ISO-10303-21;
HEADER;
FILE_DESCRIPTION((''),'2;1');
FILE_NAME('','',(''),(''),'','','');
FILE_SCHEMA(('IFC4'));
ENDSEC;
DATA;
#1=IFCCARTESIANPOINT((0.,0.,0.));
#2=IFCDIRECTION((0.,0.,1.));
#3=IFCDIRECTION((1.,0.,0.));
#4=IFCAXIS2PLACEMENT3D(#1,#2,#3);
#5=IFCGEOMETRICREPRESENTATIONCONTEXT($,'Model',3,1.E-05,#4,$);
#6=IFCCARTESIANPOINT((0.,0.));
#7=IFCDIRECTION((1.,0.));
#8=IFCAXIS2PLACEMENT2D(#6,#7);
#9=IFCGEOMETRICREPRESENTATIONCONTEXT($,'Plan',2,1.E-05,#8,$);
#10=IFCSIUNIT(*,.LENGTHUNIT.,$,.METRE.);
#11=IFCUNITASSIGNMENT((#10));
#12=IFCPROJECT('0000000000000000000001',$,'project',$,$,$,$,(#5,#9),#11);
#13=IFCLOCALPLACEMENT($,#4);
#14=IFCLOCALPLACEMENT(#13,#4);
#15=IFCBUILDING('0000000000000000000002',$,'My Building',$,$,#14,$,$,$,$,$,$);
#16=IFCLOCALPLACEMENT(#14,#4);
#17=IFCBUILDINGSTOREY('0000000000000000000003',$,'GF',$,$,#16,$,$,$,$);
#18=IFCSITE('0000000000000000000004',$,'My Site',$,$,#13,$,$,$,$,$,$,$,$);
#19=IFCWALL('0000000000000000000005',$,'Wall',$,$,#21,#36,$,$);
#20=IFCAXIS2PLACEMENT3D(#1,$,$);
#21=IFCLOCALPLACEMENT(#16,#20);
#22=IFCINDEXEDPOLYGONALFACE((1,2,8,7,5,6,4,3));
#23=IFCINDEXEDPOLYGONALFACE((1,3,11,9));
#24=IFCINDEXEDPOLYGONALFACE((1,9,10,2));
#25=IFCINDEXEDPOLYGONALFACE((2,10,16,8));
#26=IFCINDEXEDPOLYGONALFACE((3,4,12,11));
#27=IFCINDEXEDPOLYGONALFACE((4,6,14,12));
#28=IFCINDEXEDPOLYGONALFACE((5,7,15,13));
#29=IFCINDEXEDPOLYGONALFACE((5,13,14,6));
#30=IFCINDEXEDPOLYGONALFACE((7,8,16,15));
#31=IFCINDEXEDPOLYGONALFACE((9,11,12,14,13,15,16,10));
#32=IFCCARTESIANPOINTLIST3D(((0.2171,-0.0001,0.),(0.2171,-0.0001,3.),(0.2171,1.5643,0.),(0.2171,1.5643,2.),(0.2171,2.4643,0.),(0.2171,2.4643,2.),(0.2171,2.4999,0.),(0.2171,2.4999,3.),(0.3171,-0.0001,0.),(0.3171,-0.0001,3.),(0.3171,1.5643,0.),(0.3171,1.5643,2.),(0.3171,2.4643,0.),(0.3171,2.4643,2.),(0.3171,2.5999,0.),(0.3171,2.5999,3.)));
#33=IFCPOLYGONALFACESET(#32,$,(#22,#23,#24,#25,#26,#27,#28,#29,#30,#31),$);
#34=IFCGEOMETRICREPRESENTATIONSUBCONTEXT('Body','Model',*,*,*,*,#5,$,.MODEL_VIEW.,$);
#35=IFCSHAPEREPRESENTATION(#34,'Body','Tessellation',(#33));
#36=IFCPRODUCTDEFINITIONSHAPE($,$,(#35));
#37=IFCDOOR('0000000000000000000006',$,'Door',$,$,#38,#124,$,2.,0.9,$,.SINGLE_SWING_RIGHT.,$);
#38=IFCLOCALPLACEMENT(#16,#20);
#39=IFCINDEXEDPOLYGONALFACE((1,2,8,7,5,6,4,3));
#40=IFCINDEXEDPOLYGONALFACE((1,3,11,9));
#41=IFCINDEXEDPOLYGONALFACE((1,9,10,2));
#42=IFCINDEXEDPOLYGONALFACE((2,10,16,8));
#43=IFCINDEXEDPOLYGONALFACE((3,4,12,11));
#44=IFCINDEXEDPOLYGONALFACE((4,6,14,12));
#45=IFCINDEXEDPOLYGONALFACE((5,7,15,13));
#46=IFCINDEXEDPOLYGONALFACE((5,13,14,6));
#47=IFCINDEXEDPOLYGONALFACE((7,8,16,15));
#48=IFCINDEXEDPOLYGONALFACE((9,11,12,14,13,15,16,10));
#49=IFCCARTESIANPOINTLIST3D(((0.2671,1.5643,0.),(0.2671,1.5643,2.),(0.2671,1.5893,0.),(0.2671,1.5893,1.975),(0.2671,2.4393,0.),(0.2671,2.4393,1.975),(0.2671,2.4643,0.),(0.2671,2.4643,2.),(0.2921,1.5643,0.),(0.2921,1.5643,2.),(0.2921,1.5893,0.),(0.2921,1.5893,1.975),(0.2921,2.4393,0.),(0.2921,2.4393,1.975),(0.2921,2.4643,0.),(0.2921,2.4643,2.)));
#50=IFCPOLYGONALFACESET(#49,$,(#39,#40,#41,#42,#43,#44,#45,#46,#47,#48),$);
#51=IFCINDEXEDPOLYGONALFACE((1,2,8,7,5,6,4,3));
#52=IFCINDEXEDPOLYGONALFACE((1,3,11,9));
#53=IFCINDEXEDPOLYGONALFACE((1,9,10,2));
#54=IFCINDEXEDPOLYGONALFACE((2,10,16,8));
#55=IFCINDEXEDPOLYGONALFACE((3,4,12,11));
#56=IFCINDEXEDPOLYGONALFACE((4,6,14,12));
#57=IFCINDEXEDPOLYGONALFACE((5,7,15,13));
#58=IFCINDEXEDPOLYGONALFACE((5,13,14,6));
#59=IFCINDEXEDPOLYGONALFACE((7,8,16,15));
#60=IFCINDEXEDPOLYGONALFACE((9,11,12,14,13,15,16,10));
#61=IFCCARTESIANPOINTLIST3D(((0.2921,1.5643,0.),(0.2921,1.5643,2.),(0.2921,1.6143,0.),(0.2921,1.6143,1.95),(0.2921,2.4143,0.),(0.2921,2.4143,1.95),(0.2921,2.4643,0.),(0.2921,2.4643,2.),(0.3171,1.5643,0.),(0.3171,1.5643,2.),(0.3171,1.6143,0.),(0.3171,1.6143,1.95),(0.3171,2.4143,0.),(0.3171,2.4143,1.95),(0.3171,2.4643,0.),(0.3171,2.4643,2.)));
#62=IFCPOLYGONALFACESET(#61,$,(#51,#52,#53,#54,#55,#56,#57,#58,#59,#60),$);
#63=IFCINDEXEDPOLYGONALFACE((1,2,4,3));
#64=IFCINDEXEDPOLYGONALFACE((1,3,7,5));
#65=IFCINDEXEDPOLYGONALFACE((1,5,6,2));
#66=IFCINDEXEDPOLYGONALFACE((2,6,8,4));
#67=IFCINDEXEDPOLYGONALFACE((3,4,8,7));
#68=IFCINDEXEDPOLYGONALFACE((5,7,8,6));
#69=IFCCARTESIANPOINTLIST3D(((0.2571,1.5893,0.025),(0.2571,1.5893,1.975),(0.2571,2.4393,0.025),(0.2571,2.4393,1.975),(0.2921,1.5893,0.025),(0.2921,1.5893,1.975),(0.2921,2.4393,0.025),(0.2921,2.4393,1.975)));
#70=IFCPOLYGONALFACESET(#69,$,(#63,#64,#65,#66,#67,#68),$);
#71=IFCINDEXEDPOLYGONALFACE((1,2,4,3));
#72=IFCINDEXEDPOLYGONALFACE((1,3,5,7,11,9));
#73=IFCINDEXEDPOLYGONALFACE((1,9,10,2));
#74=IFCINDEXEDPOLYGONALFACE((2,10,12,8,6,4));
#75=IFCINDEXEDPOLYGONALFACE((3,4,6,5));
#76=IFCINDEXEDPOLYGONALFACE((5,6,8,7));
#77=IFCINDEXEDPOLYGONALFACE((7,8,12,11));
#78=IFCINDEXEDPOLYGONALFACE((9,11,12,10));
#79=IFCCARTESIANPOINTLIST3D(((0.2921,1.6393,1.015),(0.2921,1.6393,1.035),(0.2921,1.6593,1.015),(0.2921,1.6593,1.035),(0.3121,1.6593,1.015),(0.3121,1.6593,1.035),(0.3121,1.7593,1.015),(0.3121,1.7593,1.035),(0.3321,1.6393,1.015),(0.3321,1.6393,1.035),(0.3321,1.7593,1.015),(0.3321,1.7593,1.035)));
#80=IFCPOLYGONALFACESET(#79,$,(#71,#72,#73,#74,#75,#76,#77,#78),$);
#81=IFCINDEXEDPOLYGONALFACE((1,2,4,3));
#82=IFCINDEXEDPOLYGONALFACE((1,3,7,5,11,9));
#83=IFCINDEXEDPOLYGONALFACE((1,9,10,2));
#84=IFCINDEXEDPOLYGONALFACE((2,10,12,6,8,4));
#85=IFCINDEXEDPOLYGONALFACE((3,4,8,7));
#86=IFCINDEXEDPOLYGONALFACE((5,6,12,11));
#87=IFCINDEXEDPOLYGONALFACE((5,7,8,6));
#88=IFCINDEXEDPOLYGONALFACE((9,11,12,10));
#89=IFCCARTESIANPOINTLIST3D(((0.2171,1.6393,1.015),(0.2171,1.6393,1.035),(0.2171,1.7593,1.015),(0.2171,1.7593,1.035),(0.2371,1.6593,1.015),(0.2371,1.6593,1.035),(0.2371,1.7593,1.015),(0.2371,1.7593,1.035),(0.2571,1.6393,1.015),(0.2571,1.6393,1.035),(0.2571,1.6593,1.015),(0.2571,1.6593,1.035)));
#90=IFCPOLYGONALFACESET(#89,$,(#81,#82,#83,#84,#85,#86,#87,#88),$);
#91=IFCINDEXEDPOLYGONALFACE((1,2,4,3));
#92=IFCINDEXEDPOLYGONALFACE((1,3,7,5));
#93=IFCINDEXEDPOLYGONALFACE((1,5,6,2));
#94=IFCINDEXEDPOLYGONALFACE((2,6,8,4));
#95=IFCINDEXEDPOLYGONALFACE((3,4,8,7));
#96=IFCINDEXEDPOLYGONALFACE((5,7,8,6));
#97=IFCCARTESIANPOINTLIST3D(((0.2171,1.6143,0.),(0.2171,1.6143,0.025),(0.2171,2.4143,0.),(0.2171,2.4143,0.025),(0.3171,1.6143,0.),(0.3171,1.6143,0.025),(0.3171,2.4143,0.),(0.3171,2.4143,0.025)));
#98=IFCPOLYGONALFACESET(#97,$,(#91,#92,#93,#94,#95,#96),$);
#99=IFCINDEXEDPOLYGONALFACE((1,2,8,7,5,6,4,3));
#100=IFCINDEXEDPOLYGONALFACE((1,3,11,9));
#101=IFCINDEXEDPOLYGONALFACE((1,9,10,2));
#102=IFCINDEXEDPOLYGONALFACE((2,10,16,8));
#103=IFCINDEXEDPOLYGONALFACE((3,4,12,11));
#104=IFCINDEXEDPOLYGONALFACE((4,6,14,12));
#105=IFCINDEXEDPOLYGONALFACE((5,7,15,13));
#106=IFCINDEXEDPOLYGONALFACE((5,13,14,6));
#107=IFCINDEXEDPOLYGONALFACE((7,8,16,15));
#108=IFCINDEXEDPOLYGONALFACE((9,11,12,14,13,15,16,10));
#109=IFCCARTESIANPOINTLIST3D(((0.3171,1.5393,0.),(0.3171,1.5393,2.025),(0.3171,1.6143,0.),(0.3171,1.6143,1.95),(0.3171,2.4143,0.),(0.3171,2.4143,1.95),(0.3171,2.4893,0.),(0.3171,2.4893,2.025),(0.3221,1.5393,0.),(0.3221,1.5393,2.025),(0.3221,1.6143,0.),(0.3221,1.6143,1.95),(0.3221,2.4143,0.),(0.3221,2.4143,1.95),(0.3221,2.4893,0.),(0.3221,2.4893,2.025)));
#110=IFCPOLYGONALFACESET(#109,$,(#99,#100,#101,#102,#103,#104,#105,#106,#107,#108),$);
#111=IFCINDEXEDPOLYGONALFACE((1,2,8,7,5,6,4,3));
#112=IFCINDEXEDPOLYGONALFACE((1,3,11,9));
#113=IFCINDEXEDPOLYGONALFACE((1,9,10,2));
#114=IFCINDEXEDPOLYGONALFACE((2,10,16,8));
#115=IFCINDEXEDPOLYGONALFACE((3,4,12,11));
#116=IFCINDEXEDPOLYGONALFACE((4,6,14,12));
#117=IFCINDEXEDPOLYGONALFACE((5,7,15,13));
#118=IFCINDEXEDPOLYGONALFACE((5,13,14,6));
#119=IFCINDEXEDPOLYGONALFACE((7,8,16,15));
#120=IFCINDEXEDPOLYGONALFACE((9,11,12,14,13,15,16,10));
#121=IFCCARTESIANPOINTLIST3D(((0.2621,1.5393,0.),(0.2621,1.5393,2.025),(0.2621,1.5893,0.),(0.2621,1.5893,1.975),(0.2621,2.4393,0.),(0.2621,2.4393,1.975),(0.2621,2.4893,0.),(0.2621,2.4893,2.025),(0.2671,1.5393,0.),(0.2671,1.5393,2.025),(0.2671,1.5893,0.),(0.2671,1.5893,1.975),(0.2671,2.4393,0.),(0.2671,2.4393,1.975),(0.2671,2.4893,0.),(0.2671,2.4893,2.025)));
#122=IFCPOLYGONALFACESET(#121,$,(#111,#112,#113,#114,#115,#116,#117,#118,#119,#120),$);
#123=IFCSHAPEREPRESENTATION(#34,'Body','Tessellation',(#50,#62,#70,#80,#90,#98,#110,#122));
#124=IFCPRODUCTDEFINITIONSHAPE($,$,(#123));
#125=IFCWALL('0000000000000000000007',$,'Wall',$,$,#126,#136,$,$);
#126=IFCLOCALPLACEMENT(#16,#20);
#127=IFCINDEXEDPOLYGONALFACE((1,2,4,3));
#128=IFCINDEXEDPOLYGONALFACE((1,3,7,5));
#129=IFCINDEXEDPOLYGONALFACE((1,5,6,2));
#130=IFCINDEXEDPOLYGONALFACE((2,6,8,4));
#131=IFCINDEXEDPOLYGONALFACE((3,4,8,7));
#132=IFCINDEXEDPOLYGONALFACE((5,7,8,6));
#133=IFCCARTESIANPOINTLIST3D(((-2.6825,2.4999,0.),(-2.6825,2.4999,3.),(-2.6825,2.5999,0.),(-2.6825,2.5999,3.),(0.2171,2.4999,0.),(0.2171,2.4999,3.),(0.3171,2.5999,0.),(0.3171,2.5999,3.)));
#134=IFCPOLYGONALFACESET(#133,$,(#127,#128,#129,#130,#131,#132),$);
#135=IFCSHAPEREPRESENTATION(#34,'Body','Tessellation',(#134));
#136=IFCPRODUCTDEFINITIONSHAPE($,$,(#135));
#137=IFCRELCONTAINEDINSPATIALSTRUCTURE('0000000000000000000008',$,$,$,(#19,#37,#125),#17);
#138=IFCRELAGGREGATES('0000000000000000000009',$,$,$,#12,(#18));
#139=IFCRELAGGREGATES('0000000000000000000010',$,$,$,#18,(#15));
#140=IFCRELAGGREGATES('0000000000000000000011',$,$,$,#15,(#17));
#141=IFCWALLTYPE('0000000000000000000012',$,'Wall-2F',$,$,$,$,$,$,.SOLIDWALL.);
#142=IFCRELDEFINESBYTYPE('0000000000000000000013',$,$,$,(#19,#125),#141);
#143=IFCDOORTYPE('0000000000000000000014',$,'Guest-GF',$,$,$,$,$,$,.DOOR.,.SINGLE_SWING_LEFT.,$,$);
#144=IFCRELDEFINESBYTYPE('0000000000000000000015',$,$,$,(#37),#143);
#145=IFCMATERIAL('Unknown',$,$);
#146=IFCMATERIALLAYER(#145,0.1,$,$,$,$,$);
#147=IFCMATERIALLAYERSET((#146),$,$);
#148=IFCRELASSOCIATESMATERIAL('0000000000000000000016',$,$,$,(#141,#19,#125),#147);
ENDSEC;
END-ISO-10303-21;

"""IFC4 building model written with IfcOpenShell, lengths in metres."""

from ifc_helpers import new_model, entity, si_unit, frame, origin_with_axes, origin_2d_with_axis, place, context, subcontext, project, spatial, line, indexed_curve, outline, extrude, shape, source, transform, mapped, material, layer, layer_set, layer_usage, type_object, type_shapes, element, fill, save


model = new_model("IFC4")

# Units and contexts
model_context = context("Model", 3, precision=1e-05, world=origin_with_axes())
plan_context = context("Plan", 2, precision=1e-05, world=origin_2d_with_axis())
body_context_1 = subcontext(model_context, "Body", "Model", "MODEL_VIEW")
body_context_2 = subcontext(plan_context, "Body", "Plan", "PLAN_VIEW")
ifc_project = project(units=[si_unit("LENGTHUNIT", "METRE")], contexts=[model_context, plan_context])

# Site, building, storey
site_placement = place(None, origin_with_axes())
site = spatial("IfcSite", under=ifc_project, at=site_placement, Name="My Site")
building_placement = place(site_placement, origin_with_axes())
building = spatial("IfcBuilding", under=site, at=building_placement, Name="My Building")
storey_placement = place(building_placement, origin_with_axes())
storey = spatial("IfcBuildingStorey", under=building, at=storey_placement, Name="GF")

# Shared definitions
ifc_material = material(Name="Unknown")

# Shared definitions
ifc_layer_1 = layer(ifc_material, 0.1)
ifc_layer_set_1 = layer_set([ifc_layer_1])
wall_type = type_object("IfcWallType", Name="Wall-2F", PredefinedType="SOLIDWALL", material=ifc_layer_set_1)

# Wall, opening, door
ifc_layer_usage_1 = layer_usage(ifc_layer_set_1, "AXIS2", "POSITIVE", 0.0)
wall_1_placement = place(storey_placement, frame((0.3171, -0.0001, 0.0), z_axis=(0.0, 0.0, 1.0), x_axis=(0.0, 1.0, 0.0)))
wall_1 = element("IfcWall", 1, at=wall_1_placement, inside=storey, type_object=wall_type, material=ifc_layer_usage_1, Name="Wall", context=body_context_1, shape_type="SweptSolid", body=[
    extrude(outline(indexed_curve([(0.0, 0.0), (0.0, 0.1), (2.5, 0.1), (2.6, 0.0)], segments=[line(1, 2, 3, 4, 1)])), origin_with_axes(), (0.0, 0.0, 1.0), 3.0),
])
shared_shape_1 = source(origin_with_axes(), body_context_1, "Body", "SweptSolid", [
    extrude(outline(indexed_curve([(0.0, 0.0), (0.9, 0.0), (0.9, 2.0), (0.0, 2.0)], segments=[line(1, 2, 3, 4, 1)])), frame((0.0, -0.6, 0.0), z_axis=(0.0, -1.0, 0.0), x_axis=(1.0, 0.0, 0.0)), (0.0, 0.0, -1.0), 1.2),
])
opening_1_placement = place(wall_1_placement, frame((1.5644, 0.0, 0.0), z_axis=(0.0, 0.0, 1.0), x_axis=(1.0, 0.0, 0.0)))
opening_1 = element("IfcOpeningElement", 2, at=opening_1_placement, cuts=wall_1, PredefinedType="OPENING", context=body_context_1, shape_type="MappedRepresentation", body=[
    mapped(shared_shape_1, transform((0.0, 0.0, 0.0), x_axis=(1.0, 0.0, 0.0), y_axis=(0.0, 1.0, 0.0), z_axis=(0.0, 0.0, 1.0), scale=1.0)),
])
door_type_1 = type_object("IfcDoorType", Name="Guest-GF", OperationType="SINGLE_SWING_LEFT", PredefinedType="DOOR")
shared_shape_2 = source(origin_with_axes(), body_context_1, "Body", "SweptSolid", [
    extrude(outline(indexed_curve([(0.0, 0.0), (0.0, 2.0), (0.9, 2.0), (0.9, 0.0), (0.875, 0.0), (0.875, 1.975), (0.025, 1.975), (0.025, 0.0)], segments=[line(1, 2, 3, 4, 5, 6, 7, 8, 1)])), frame((0.0, 0.025, 0.0), z_axis=(0.0, -1.0, 0.0), x_axis=(1.0, 0.0, 0.0)), (0.0, 0.0, -1.0), 0.025),
    extrude(outline(indexed_curve([(0.0, 0.0), (0.0, 2.0), (0.9, 2.0), (0.9, 0.0), (0.85, 0.0), (0.85, 1.95), (0.05, 1.95), (0.05, 0.0)], segments=[line(1, 2, 3, 4, 5, 6, 7, 8, 1)])), frame((0.0, 0.0, 0.0), z_axis=(0.0, -1.0, 0.0), x_axis=(1.0, 0.0, 0.0)), (0.0, 0.0, -1.0), 0.025),
    extrude(outline(indexed_curve([(0.0, 0.0), (0.85, 0.0), (0.85, 0.035), (0.0, 0.035)], segments=[line(1, 2, 3, 4, 1)])), frame((0.025, 0.025, 0.025), z_axis=(0.0, 0.0, 1.0), x_axis=(1.0, 0.0, 0.0)), (0.0, 0.0, 1.0), 1.95),
    extrude(outline(indexed_curve([(0.0, 0.0), (0.0, -0.04), (0.12, -0.04), (0.12, -0.02), (0.02, -0.02), (0.02, 0.0)], segments=[line(1, 2, 3, 4, 5, 6, 1)])), frame((0.075, 0.025, 1.015), z_axis=(0.0, 0.0, 1.0), x_axis=(1.0, 0.0, 0.0)), (0.0, 0.0, 1.0), 0.02),
    extrude(outline(indexed_curve([(0.0, 0.0), (0.0, 0.04), (0.12, 0.04), (0.12, 0.02), (0.02, 0.02), (0.02, 0.0)], segments=[line(1, 2, 3, 4, 5, 6, 1)])), frame((0.075, 0.06, 1.015), z_axis=(0.0, 0.0, 1.0), x_axis=(1.0, 0.0, 0.0)), (0.0, 0.0, 1.0), 0.02),
    extrude(outline(indexed_curve([(0.0, 0.0), (0.8, 0.0), (0.8, 0.1), (0.0, 0.1)], segments=[line(1, 2, 3, 4, 1)])), frame((0.05, 0.0, 0.0), z_axis=(0.0, 0.0, 1.0), x_axis=(1.0, 0.0, 0.0)), (0.0, 0.0, 1.0), 0.025),
    extrude(outline(indexed_curve([(0.0, 0.0), (0.0, 2.025), (0.95, 2.025), (0.95, 0.0), (0.875, 0.0), (0.875, 1.95), (0.075, 1.95), (0.075, 0.0)], segments=[line(1, 2, 3, 4, 5, 6, 7, 8, 1)])), frame((-0.025, -0.005, 0.0), z_axis=(0.0, -1.0, 0.0), x_axis=(1.0, 0.0, 0.0)), (0.0, 0.0, -1.0), 0.005),
    extrude(outline(indexed_curve([(0.0, 0.0), (0.0, 2.025), (0.95, 2.025), (0.95, 0.0), (0.9, 0.0), (0.9, 1.975), (0.05, 1.975), (0.05, 0.0)], segments=[line(1, 2, 3, 4, 5, 6, 7, 8, 1)])), frame((-0.025, 0.05, 0.0), z_axis=(0.0, -1.0, 0.0), x_axis=(1.0, 0.0, 0.0)), (0.0, 0.0, -1.0), 0.005),
])
shared_shape_3 = source(origin_with_axes(), body_context_2, "Body", "Curve2D", [
    entity("IfcIndexedPolyCurve", entity("IfcCartesianPointList2D", [[0.0, 0.0], [0.0, 0.05], [0.025, 0.05], [0.025, 0.025], [0.05, 0.025], [0.05, 0.0]]), [entity("IfcLineIndex", [1, 2, 3, 4, 5, 6, 1])]),
    entity("IfcIndexedPolyCurve", entity("IfcCartesianPointList2D", [[0.9, 0.0], [0.9, 0.05], [0.875, 0.05], [0.875, 0.025], [0.85, 0.025], [0.85, 0.0]]), [entity("IfcLineIndex", [1, 2, 3, 4, 5, 6, 1])]),
    entity("IfcTrimmedCurve", entity("IfcEllipse", entity("IfcAxis2Placement2D", entity("IfcCartesianPoint", [0.84, 0.05]), entity("IfcDirection", [1.0, 0.0])), 0.815, 0.85), [entity("IfcCartesianPoint", [0.84, 0.9])], [entity("IfcCartesianPoint", [0.025, 0.05])], True, "CARTESIAN"),
    entity("IfcIndexedPolyCurve", entity("IfcCartesianPointList2D", [[0.875, 0.05], [0.84, 0.05], [0.84, 0.9], [0.875, 0.9]]), [entity("IfcLineIndex", [1, 2, 3, 4, 1])]),
])
type_shapes(door_type_1, [shared_shape_2, shared_shape_3])
door_1_placement = place(opening_1_placement, frame((0.0, 0.0, 0.0), z_axis=(0.0, 0.0, 1.0), x_axis=(1.0, 0.0, 0.0)))
door_1 = element("IfcDoor", 3, at=door_1_placement, inside=storey, type_object=door_type_1, Name="Door", OperationType="SINGLE_SWING_RIGHT", OverallHeight=2.0, OverallWidth=0.9, shapes=[
    shape(body_context_1, "Body", "MappedRepresentation", [mapped(shared_shape_2, transform((0.0, 0.0, 0.0), x_axis=(1.0, 0.0, 0.0), y_axis=(0.0, 1.0, 0.0), z_axis=(0.0, 0.0, 1.0), scale=1.0))]),
    shape(body_context_2, "Body", "MappedRepresentation", [mapped(shared_shape_3, transform((0.0, 0.0, 0.0), x_axis=(1.0, 0.0, 0.0), y_axis=(0.0, 1.0, 0.0), z_axis=(0.0, 0.0, 1.0), scale=1.0))]),
])
fill(opening_1, door_1)

# Wall
ifc_layer_usage_2 = layer_usage(ifc_layer_set_1, "AXIS2", "POSITIVE", 0.0)
wall_2_placement = place(storey_placement, frame((0.3171, 2.5999, 0.0), z_axis=(0.0, 0.0, 1.0), x_axis=(-1.0, 0.0, 0.0)))
element("IfcWall", 4, at=wall_2_placement, inside=storey, type_object=wall_type, material=ifc_layer_usage_2, Name="Wall", context=body_context_1, shape_type="SweptSolid", body=[
    extrude(outline(indexed_curve([(0.0, 0.0), (0.1, 0.1), (2.9996, 0.1), (2.9996, 0.0)], segments=[line(1, 2, 3, 4, 1)])), origin_with_axes(), (0.0, 0.0, 1.0), 3.0),
])

save(model, "model.ifc")
